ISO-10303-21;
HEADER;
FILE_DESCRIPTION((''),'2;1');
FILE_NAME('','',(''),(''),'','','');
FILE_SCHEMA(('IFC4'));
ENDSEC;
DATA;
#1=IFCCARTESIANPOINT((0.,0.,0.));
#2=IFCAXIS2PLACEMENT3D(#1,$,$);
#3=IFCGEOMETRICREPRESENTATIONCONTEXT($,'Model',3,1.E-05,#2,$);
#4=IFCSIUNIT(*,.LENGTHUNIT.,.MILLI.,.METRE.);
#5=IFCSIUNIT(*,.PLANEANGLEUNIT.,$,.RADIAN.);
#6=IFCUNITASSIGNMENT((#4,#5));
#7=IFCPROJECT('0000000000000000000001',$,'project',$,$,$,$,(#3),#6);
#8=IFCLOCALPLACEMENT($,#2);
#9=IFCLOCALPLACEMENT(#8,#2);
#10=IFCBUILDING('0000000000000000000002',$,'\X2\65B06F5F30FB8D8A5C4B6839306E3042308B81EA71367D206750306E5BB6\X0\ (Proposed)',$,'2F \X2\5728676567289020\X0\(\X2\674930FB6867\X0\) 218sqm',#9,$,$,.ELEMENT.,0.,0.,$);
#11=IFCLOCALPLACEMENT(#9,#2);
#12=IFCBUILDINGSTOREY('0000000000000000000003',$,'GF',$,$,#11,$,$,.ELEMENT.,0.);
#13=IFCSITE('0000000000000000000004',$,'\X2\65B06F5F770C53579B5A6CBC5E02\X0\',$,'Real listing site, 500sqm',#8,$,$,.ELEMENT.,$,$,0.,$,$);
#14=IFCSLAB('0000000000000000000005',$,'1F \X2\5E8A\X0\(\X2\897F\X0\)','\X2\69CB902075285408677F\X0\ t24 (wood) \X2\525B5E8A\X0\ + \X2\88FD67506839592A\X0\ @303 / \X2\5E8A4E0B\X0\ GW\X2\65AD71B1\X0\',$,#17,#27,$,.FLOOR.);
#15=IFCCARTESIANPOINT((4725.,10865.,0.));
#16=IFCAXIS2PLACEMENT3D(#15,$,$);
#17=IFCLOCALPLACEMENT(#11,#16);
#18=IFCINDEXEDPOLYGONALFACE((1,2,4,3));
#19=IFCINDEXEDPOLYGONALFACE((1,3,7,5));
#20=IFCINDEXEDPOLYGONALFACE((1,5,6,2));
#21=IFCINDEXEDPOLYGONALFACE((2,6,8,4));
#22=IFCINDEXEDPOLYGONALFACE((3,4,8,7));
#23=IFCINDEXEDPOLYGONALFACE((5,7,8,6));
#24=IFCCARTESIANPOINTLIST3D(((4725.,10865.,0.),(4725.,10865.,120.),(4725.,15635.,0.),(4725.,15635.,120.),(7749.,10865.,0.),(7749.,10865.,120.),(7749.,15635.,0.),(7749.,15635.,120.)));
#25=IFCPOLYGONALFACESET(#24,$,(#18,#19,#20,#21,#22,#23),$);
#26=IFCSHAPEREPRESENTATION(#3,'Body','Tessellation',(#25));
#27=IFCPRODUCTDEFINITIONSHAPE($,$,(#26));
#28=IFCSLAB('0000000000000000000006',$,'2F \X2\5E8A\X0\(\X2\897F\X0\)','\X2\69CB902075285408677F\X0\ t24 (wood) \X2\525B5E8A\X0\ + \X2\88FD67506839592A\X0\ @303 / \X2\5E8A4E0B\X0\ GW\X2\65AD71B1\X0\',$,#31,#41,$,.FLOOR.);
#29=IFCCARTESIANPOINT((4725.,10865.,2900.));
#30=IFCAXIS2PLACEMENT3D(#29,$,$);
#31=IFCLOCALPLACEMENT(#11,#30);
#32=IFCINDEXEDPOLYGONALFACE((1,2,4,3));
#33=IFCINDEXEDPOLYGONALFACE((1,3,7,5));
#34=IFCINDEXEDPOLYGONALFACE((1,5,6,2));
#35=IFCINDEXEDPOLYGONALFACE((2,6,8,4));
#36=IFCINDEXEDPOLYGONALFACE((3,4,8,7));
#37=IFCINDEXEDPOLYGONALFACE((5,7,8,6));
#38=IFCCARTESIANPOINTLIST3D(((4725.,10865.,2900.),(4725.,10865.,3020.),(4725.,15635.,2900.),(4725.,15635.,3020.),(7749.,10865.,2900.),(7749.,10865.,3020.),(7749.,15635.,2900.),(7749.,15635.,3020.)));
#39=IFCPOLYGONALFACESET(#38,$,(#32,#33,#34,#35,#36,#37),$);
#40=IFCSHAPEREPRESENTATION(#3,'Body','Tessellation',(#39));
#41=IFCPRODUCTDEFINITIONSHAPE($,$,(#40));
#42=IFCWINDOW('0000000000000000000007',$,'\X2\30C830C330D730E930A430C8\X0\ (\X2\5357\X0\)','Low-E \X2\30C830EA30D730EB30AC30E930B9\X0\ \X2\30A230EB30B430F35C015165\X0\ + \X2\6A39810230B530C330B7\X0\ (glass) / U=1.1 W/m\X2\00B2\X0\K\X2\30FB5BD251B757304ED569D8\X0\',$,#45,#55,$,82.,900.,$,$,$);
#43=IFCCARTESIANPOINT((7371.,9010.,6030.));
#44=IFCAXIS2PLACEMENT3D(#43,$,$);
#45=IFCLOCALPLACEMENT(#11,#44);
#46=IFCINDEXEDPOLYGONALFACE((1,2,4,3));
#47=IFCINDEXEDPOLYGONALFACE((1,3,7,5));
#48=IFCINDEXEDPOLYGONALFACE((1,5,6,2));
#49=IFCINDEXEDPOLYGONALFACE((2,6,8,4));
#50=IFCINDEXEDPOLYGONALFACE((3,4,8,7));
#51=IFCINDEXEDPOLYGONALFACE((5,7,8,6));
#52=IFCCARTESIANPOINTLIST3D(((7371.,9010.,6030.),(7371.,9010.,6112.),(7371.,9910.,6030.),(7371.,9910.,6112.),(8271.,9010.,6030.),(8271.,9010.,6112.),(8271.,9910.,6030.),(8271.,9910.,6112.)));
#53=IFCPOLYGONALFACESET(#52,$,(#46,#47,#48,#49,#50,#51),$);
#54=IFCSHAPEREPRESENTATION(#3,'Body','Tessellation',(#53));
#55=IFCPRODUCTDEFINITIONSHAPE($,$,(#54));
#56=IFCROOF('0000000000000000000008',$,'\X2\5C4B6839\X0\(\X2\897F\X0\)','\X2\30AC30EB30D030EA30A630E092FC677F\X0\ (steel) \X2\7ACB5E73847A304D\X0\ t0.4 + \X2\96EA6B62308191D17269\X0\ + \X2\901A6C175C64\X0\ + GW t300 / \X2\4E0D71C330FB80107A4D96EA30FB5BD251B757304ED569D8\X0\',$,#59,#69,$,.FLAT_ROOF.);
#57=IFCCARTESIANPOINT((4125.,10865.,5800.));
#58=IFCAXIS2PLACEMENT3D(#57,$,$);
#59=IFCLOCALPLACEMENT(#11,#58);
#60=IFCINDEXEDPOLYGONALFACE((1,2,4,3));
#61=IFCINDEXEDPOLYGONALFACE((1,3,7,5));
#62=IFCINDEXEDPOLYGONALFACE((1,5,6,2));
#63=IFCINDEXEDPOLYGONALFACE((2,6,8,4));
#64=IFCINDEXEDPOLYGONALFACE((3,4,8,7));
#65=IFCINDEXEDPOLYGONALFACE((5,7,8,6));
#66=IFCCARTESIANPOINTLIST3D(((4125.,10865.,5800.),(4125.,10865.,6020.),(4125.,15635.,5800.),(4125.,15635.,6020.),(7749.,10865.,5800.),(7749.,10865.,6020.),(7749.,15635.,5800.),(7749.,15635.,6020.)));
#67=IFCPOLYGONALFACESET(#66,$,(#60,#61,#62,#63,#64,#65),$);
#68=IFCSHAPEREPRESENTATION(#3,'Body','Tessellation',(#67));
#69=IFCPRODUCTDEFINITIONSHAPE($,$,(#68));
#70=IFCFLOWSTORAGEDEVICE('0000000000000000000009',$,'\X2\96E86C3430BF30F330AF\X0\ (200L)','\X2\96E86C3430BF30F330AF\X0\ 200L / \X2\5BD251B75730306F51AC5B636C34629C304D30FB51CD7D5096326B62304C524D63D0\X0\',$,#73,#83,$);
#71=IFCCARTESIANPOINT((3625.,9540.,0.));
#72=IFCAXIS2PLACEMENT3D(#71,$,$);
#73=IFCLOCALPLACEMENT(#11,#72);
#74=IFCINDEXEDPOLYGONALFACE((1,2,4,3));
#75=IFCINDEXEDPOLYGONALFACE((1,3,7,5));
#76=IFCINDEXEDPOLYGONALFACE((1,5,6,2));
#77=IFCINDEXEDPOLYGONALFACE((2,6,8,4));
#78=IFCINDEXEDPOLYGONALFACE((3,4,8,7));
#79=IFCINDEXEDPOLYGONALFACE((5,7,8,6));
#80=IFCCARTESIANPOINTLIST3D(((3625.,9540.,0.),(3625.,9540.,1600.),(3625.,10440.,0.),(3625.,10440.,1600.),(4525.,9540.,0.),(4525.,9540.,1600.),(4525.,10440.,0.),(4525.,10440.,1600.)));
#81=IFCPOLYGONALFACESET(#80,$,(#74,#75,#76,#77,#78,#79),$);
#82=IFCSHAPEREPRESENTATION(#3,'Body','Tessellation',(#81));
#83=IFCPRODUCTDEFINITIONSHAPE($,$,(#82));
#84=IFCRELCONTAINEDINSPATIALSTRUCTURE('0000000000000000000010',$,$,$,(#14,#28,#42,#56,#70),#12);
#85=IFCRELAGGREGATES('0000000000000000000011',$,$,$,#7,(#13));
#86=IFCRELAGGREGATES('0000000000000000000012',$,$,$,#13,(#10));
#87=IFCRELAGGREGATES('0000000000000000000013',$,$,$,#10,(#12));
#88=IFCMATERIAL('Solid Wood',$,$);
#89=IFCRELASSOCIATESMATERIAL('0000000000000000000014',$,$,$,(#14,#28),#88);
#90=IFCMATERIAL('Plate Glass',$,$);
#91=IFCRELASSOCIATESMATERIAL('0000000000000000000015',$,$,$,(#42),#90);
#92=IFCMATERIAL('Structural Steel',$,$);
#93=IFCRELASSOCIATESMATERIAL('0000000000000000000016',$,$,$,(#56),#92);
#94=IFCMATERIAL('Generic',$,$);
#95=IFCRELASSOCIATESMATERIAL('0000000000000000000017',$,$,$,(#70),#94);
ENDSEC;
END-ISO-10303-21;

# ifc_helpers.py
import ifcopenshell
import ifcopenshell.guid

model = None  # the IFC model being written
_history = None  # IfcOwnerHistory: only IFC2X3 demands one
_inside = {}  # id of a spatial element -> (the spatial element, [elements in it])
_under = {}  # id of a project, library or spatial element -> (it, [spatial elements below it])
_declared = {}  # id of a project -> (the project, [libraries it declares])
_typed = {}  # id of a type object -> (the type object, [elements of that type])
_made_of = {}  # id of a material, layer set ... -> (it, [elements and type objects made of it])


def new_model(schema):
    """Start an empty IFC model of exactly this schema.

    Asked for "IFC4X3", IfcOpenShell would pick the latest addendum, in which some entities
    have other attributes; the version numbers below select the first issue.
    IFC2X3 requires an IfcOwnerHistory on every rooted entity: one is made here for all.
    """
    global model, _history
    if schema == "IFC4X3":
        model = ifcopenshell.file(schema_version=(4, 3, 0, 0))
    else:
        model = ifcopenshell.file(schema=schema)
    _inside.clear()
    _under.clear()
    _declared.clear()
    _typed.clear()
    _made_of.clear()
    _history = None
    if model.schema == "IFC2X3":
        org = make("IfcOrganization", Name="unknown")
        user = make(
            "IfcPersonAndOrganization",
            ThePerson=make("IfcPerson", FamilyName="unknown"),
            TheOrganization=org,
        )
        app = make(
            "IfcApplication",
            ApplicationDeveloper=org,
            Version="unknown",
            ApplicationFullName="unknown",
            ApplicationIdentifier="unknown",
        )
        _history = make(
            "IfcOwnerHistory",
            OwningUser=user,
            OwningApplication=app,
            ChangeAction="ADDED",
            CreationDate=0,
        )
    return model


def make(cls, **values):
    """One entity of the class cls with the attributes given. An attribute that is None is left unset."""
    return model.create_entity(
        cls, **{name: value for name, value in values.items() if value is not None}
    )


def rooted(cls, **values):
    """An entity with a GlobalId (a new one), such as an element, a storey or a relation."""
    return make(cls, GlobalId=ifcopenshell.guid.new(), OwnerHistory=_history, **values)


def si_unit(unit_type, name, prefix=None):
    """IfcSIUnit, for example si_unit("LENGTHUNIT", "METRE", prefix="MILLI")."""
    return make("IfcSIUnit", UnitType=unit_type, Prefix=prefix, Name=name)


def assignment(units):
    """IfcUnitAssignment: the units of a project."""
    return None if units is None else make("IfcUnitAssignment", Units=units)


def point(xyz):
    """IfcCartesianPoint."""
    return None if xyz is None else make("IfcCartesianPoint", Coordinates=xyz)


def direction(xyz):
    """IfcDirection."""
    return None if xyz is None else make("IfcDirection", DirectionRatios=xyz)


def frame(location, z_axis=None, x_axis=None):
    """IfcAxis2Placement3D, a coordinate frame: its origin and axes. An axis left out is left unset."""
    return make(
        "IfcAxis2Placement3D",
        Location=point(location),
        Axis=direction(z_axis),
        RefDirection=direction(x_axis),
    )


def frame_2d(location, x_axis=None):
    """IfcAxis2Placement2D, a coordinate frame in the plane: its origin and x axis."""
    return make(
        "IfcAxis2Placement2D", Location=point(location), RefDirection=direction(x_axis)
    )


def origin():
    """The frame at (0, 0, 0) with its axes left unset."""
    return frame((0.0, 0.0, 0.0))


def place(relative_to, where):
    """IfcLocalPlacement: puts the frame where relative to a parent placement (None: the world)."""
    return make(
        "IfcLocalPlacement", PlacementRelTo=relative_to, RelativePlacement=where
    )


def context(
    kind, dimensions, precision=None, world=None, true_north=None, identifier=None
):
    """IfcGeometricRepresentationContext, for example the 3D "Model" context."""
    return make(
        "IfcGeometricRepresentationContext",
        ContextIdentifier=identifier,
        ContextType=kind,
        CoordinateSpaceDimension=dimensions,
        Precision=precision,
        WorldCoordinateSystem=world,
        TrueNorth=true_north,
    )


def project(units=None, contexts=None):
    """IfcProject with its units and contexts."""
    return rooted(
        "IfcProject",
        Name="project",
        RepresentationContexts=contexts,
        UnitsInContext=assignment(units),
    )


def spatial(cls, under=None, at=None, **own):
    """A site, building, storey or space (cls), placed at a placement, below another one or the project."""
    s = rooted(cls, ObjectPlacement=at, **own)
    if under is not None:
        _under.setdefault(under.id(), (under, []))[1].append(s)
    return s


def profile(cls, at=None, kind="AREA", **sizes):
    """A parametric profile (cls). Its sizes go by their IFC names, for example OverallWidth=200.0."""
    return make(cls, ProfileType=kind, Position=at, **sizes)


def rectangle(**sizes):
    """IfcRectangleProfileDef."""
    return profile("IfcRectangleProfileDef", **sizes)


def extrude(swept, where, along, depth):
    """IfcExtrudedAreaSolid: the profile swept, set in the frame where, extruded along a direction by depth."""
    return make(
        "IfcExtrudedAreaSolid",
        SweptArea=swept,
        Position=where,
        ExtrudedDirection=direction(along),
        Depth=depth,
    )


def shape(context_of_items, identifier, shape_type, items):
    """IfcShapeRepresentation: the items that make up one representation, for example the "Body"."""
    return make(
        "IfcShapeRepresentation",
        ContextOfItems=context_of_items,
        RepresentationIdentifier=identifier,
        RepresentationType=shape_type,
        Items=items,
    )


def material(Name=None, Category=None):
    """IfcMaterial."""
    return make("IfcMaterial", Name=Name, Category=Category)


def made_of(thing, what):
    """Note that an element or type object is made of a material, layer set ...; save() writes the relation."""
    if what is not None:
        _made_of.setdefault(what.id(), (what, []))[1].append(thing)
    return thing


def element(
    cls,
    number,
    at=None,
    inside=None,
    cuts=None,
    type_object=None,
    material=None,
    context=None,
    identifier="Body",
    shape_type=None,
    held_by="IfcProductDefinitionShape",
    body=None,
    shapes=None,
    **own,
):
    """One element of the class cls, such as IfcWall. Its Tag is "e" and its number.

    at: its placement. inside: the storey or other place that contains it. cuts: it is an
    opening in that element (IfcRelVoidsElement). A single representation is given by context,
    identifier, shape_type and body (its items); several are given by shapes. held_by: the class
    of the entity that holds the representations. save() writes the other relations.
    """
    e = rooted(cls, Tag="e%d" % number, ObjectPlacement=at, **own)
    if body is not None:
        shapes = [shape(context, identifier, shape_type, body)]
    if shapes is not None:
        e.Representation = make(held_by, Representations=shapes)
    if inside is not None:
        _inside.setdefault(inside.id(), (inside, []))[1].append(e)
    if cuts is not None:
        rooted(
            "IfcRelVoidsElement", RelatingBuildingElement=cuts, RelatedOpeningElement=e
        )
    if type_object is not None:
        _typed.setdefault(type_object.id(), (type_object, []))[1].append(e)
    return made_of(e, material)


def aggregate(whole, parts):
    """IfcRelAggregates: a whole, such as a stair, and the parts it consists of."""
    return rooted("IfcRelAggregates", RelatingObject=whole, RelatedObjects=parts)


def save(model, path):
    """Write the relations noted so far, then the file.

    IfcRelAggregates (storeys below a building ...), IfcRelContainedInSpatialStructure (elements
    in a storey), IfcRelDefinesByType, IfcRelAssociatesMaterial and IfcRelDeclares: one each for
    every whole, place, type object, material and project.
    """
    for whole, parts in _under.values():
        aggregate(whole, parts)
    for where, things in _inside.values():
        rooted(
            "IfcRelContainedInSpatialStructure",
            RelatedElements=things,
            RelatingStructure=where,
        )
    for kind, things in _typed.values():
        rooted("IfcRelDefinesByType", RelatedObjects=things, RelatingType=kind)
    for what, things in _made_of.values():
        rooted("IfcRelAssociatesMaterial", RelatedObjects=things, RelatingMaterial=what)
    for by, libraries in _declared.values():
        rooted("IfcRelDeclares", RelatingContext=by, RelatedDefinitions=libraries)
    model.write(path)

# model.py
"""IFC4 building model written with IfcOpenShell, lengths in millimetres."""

from ifc_helpers import new_model, si_unit, frame, frame_2d, origin, place, context, project, spatial, rectangle, extrude, material, element, save


model = new_model("IFC4")

# Units and contexts
model_context = context("Model", 3, precision=1e-05, world=origin())
ifc_project = project(units=[si_unit("LENGTHUNIT", "METRE", prefix="MILLI"), si_unit("PLANEANGLEUNIT", "RADIAN")], contexts=[model_context])

# Site, building, storey
site_placement = place(None, origin())
site = spatial("IfcSite", under=ifc_project, at=site_placement, Name="新潟県南魚沼市", ObjectType="Real listing site, 500sqm", CompositionType="ELEMENT", RefElevation=0.0)
building_placement = place(site_placement, origin())
building = spatial("IfcBuilding", under=site, at=building_placement, Name="新潟・越屋根のある自然素材の家 (Proposed)", ObjectType="2F 在来木造(杉・桧) 218sqm", CompositionType="ELEMENT", ElevationOfRefHeight=0.0, ElevationOfTerrain=0.0)
storey_placement = place(building_placement, origin())
storey = spatial("IfcBuildingStorey", under=building, at=storey_placement, Name="GF", CompositionType="ELEMENT", Elevation=0.0)

# Shared definitions
ifc_material_1 = material(Name="Solid Wood")

# Slabs
slab_1_placement = place(storey_placement, frame((4725.0, 10865.0, 0.0)))
element("IfcSlab", 1, at=slab_1_placement, inside=storey, material=ifc_material_1, Name="1F 床(西)", Description="構造用合板 t24 (wood) 剛床 + 製材根太 @303 / 床下 GW断熱", PredefinedType="FLOOR", context=model_context, shape_type="SweptSolid", body=[
    extrude(rectangle(XDim=3024.0, YDim=4770.0, at=frame_2d((1512.0, 2385.0))), frame((4725.0, 10865.0, 0.0)), (0.0, 0.0, 1.0), 120.0),
])
slab_2_placement = place(storey_placement, frame((4725.0, 10865.0, 2900.0)))
element("IfcSlab", 2, at=slab_2_placement, inside=storey, material=ifc_material_1, Name="2F 床(西)", Description="構造用合板 t24 (wood) 剛床 + 製材根太 @303 / 床下 GW断熱", PredefinedType="FLOOR", context=model_context, shape_type="SweptSolid", body=[
    extrude(rectangle(XDim=3024.0, YDim=4770.0, at=frame_2d((1512.0, 2385.0))), frame((4725.0, 10865.0, 2900.0)), (0.0, 0.0, 1.0), 120.0),
])

# Window
ifc_material_2 = material(Name="Plate Glass")
window_placement = place(storey_placement, frame((7371.0, 9010.0, 6030.0)))
element("IfcWindow", 3, at=window_placement, inside=storey, material=ifc_material_2, Name="トップライト (南)", Description="Low-E トリプルガラス アルゴン封入 + 樹脂サッシ (glass) / U=1.1 W/m²K・寒冷地仕様", OverallHeight=82.0, OverallWidth=900.0, context=model_context, shape_type="SweptSolid", body=[
    extrude(rectangle(XDim=900.0, YDim=900.0, at=frame_2d((450.0, 450.0))), frame((7371.0, 9010.0, 6030.0)), (0.0, 0.0, 1.0), 82.0),
])

# Roof
ifc_material_3 = material(Name="Structural Steel")
for number, where, name in (
    (4, (4125.0, 10865.0, 5800.0), "屋根(西)"),
):
    element("IfcRoof", number, at=place(storey_placement, frame(where)), inside=storey, material=ifc_material_3, Name=name, Description="ガルバリウム鋼板 (steel) 立平葺き t0.4 + 雪止め金物 + 通気層 + GW t300 / 不燃・耐積雪・寒冷地仕様", PredefinedType="FLAT_ROOF", context=model_context, shape_type="SweptSolid", body=[
        extrude(rectangle(XDim=3624.0, YDim=4770.0, at=frame_2d((1812.0, 2385.0))), frame((4125.0, 10865.0, 5800.0)), (0.0, 0.0, 1.0), 220.0),
    ])

# Flow storage device
ifc_material_4 = material(Name="Generic")
flow_storage_device_placement = place(storey_placement, frame((3625.0, 9540.0, 0.0)))
element("IfcFlowStorageDevice", 5, at=flow_storage_device_placement, inside=storey, material=ifc_material_4, Name="雨水タンク (200L)", Description="雨水タンク 200L / 寒冷地は冬季水抜き・凍結防止が前提", context=model_context, shape_type="SweptSolid", body=[
    extrude(rectangle(XDim=900.0, YDim=900.0, at=frame_2d((450.0, 450.0))), frame((3625.0, 9540.0, 0.0)), (0.0, 0.0, 1.0), 1600.0),
])

save(model, "model.ifc")
